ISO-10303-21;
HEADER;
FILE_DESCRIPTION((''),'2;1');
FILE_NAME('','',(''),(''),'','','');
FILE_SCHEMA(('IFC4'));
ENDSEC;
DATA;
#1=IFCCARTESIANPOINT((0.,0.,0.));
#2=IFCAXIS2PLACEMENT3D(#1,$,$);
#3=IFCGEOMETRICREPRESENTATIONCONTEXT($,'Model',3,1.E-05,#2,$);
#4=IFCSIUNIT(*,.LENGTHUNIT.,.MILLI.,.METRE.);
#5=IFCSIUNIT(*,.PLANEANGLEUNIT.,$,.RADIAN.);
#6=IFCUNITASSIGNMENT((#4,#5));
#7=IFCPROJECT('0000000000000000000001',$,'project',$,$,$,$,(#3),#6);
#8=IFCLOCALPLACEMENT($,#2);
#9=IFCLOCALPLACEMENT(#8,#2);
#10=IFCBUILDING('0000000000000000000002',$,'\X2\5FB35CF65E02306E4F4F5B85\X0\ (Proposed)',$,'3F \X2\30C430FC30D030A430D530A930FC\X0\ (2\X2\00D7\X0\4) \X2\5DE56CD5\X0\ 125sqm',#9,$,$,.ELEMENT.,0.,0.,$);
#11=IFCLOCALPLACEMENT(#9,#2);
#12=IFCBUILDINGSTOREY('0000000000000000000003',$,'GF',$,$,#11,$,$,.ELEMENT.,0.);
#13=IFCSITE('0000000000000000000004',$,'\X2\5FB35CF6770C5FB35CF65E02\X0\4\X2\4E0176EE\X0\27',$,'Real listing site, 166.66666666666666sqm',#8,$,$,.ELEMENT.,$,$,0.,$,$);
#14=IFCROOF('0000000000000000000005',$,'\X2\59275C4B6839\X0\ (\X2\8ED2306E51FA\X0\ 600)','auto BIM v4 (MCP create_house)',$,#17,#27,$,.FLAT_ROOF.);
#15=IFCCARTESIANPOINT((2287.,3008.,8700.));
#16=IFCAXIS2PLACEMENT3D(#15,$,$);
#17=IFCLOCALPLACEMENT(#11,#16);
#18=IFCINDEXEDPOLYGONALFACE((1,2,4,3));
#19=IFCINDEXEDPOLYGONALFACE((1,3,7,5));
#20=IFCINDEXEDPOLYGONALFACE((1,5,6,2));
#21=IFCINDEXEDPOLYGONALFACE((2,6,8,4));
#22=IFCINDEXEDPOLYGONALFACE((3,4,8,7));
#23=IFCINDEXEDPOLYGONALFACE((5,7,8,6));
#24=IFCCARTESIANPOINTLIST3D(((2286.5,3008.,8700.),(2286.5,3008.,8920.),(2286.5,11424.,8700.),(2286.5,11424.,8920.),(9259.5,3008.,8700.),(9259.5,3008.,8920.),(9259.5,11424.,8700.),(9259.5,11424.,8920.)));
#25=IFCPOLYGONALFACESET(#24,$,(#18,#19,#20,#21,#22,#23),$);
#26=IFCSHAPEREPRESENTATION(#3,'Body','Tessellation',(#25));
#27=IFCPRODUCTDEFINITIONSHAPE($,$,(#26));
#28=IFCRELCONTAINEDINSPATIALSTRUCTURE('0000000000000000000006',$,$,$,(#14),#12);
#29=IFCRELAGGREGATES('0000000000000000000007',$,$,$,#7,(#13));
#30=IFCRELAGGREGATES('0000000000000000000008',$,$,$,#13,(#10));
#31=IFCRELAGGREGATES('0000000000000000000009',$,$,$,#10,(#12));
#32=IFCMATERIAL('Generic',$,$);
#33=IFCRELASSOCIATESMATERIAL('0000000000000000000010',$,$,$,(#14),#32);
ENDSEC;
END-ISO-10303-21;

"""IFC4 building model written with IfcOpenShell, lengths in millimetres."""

from ifc_helpers import new_model, si_unit, frame, frame_2d, origin, place, context, project, spatial, rectangle, extrude, material, element, save


model = new_model("IFC4")

# Units and contexts
model_context = context("Model", 3, precision=1e-05, world=origin())
ifc_project = project(units=[si_unit("LENGTHUNIT", "METRE", prefix="MILLI"), si_unit("PLANEANGLEUNIT", "RADIAN")], contexts=[model_context])

# Site, building, storey
site_placement = place(None, origin())
site = spatial("IfcSite", under=ifc_project, at=site_placement, Name="徳島県徳島市4丁目27", ObjectType="Real listing site, 166.66666666666666sqm", CompositionType="ELEMENT", RefElevation=0.0)
building_placement = place(site_placement, origin())
building = spatial("IfcBuilding", under=site, at=building_placement, Name="徳島市の住宅 (Proposed)", ObjectType="3F ツーバイフォー (2×4) 工法 125sqm", CompositionType="ELEMENT", ElevationOfRefHeight=0.0, ElevationOfTerrain=0.0)
storey_placement = place(building_placement, origin())
storey = spatial("IfcBuildingStorey", under=building, at=storey_placement, Name="GF", CompositionType="ELEMENT", Elevation=0.0)

# Shared definitions
ifc_material = material(Name="Generic")

# Roof
roof_placement = place(storey_placement, frame((2287.0, 3008.0, 8700.0)))
element("IfcRoof", 1, at=roof_placement, inside=storey, material=ifc_material, Name="大屋根 (軒の出 600)", Description="auto BIM v4 (MCP create_house)", PredefinedType="FLAT_ROOF", context=model_context, shape_type="SweptSolid", body=[
    extrude(rectangle(XDim=6973.0, YDim=8416.0, at=frame_2d((3486.0, 4208.0))), frame((2287.0, 3008.0, 8700.0)), (0.0, 0.0, 1.0), 220.0),
])

save(model, "model.ifc")
